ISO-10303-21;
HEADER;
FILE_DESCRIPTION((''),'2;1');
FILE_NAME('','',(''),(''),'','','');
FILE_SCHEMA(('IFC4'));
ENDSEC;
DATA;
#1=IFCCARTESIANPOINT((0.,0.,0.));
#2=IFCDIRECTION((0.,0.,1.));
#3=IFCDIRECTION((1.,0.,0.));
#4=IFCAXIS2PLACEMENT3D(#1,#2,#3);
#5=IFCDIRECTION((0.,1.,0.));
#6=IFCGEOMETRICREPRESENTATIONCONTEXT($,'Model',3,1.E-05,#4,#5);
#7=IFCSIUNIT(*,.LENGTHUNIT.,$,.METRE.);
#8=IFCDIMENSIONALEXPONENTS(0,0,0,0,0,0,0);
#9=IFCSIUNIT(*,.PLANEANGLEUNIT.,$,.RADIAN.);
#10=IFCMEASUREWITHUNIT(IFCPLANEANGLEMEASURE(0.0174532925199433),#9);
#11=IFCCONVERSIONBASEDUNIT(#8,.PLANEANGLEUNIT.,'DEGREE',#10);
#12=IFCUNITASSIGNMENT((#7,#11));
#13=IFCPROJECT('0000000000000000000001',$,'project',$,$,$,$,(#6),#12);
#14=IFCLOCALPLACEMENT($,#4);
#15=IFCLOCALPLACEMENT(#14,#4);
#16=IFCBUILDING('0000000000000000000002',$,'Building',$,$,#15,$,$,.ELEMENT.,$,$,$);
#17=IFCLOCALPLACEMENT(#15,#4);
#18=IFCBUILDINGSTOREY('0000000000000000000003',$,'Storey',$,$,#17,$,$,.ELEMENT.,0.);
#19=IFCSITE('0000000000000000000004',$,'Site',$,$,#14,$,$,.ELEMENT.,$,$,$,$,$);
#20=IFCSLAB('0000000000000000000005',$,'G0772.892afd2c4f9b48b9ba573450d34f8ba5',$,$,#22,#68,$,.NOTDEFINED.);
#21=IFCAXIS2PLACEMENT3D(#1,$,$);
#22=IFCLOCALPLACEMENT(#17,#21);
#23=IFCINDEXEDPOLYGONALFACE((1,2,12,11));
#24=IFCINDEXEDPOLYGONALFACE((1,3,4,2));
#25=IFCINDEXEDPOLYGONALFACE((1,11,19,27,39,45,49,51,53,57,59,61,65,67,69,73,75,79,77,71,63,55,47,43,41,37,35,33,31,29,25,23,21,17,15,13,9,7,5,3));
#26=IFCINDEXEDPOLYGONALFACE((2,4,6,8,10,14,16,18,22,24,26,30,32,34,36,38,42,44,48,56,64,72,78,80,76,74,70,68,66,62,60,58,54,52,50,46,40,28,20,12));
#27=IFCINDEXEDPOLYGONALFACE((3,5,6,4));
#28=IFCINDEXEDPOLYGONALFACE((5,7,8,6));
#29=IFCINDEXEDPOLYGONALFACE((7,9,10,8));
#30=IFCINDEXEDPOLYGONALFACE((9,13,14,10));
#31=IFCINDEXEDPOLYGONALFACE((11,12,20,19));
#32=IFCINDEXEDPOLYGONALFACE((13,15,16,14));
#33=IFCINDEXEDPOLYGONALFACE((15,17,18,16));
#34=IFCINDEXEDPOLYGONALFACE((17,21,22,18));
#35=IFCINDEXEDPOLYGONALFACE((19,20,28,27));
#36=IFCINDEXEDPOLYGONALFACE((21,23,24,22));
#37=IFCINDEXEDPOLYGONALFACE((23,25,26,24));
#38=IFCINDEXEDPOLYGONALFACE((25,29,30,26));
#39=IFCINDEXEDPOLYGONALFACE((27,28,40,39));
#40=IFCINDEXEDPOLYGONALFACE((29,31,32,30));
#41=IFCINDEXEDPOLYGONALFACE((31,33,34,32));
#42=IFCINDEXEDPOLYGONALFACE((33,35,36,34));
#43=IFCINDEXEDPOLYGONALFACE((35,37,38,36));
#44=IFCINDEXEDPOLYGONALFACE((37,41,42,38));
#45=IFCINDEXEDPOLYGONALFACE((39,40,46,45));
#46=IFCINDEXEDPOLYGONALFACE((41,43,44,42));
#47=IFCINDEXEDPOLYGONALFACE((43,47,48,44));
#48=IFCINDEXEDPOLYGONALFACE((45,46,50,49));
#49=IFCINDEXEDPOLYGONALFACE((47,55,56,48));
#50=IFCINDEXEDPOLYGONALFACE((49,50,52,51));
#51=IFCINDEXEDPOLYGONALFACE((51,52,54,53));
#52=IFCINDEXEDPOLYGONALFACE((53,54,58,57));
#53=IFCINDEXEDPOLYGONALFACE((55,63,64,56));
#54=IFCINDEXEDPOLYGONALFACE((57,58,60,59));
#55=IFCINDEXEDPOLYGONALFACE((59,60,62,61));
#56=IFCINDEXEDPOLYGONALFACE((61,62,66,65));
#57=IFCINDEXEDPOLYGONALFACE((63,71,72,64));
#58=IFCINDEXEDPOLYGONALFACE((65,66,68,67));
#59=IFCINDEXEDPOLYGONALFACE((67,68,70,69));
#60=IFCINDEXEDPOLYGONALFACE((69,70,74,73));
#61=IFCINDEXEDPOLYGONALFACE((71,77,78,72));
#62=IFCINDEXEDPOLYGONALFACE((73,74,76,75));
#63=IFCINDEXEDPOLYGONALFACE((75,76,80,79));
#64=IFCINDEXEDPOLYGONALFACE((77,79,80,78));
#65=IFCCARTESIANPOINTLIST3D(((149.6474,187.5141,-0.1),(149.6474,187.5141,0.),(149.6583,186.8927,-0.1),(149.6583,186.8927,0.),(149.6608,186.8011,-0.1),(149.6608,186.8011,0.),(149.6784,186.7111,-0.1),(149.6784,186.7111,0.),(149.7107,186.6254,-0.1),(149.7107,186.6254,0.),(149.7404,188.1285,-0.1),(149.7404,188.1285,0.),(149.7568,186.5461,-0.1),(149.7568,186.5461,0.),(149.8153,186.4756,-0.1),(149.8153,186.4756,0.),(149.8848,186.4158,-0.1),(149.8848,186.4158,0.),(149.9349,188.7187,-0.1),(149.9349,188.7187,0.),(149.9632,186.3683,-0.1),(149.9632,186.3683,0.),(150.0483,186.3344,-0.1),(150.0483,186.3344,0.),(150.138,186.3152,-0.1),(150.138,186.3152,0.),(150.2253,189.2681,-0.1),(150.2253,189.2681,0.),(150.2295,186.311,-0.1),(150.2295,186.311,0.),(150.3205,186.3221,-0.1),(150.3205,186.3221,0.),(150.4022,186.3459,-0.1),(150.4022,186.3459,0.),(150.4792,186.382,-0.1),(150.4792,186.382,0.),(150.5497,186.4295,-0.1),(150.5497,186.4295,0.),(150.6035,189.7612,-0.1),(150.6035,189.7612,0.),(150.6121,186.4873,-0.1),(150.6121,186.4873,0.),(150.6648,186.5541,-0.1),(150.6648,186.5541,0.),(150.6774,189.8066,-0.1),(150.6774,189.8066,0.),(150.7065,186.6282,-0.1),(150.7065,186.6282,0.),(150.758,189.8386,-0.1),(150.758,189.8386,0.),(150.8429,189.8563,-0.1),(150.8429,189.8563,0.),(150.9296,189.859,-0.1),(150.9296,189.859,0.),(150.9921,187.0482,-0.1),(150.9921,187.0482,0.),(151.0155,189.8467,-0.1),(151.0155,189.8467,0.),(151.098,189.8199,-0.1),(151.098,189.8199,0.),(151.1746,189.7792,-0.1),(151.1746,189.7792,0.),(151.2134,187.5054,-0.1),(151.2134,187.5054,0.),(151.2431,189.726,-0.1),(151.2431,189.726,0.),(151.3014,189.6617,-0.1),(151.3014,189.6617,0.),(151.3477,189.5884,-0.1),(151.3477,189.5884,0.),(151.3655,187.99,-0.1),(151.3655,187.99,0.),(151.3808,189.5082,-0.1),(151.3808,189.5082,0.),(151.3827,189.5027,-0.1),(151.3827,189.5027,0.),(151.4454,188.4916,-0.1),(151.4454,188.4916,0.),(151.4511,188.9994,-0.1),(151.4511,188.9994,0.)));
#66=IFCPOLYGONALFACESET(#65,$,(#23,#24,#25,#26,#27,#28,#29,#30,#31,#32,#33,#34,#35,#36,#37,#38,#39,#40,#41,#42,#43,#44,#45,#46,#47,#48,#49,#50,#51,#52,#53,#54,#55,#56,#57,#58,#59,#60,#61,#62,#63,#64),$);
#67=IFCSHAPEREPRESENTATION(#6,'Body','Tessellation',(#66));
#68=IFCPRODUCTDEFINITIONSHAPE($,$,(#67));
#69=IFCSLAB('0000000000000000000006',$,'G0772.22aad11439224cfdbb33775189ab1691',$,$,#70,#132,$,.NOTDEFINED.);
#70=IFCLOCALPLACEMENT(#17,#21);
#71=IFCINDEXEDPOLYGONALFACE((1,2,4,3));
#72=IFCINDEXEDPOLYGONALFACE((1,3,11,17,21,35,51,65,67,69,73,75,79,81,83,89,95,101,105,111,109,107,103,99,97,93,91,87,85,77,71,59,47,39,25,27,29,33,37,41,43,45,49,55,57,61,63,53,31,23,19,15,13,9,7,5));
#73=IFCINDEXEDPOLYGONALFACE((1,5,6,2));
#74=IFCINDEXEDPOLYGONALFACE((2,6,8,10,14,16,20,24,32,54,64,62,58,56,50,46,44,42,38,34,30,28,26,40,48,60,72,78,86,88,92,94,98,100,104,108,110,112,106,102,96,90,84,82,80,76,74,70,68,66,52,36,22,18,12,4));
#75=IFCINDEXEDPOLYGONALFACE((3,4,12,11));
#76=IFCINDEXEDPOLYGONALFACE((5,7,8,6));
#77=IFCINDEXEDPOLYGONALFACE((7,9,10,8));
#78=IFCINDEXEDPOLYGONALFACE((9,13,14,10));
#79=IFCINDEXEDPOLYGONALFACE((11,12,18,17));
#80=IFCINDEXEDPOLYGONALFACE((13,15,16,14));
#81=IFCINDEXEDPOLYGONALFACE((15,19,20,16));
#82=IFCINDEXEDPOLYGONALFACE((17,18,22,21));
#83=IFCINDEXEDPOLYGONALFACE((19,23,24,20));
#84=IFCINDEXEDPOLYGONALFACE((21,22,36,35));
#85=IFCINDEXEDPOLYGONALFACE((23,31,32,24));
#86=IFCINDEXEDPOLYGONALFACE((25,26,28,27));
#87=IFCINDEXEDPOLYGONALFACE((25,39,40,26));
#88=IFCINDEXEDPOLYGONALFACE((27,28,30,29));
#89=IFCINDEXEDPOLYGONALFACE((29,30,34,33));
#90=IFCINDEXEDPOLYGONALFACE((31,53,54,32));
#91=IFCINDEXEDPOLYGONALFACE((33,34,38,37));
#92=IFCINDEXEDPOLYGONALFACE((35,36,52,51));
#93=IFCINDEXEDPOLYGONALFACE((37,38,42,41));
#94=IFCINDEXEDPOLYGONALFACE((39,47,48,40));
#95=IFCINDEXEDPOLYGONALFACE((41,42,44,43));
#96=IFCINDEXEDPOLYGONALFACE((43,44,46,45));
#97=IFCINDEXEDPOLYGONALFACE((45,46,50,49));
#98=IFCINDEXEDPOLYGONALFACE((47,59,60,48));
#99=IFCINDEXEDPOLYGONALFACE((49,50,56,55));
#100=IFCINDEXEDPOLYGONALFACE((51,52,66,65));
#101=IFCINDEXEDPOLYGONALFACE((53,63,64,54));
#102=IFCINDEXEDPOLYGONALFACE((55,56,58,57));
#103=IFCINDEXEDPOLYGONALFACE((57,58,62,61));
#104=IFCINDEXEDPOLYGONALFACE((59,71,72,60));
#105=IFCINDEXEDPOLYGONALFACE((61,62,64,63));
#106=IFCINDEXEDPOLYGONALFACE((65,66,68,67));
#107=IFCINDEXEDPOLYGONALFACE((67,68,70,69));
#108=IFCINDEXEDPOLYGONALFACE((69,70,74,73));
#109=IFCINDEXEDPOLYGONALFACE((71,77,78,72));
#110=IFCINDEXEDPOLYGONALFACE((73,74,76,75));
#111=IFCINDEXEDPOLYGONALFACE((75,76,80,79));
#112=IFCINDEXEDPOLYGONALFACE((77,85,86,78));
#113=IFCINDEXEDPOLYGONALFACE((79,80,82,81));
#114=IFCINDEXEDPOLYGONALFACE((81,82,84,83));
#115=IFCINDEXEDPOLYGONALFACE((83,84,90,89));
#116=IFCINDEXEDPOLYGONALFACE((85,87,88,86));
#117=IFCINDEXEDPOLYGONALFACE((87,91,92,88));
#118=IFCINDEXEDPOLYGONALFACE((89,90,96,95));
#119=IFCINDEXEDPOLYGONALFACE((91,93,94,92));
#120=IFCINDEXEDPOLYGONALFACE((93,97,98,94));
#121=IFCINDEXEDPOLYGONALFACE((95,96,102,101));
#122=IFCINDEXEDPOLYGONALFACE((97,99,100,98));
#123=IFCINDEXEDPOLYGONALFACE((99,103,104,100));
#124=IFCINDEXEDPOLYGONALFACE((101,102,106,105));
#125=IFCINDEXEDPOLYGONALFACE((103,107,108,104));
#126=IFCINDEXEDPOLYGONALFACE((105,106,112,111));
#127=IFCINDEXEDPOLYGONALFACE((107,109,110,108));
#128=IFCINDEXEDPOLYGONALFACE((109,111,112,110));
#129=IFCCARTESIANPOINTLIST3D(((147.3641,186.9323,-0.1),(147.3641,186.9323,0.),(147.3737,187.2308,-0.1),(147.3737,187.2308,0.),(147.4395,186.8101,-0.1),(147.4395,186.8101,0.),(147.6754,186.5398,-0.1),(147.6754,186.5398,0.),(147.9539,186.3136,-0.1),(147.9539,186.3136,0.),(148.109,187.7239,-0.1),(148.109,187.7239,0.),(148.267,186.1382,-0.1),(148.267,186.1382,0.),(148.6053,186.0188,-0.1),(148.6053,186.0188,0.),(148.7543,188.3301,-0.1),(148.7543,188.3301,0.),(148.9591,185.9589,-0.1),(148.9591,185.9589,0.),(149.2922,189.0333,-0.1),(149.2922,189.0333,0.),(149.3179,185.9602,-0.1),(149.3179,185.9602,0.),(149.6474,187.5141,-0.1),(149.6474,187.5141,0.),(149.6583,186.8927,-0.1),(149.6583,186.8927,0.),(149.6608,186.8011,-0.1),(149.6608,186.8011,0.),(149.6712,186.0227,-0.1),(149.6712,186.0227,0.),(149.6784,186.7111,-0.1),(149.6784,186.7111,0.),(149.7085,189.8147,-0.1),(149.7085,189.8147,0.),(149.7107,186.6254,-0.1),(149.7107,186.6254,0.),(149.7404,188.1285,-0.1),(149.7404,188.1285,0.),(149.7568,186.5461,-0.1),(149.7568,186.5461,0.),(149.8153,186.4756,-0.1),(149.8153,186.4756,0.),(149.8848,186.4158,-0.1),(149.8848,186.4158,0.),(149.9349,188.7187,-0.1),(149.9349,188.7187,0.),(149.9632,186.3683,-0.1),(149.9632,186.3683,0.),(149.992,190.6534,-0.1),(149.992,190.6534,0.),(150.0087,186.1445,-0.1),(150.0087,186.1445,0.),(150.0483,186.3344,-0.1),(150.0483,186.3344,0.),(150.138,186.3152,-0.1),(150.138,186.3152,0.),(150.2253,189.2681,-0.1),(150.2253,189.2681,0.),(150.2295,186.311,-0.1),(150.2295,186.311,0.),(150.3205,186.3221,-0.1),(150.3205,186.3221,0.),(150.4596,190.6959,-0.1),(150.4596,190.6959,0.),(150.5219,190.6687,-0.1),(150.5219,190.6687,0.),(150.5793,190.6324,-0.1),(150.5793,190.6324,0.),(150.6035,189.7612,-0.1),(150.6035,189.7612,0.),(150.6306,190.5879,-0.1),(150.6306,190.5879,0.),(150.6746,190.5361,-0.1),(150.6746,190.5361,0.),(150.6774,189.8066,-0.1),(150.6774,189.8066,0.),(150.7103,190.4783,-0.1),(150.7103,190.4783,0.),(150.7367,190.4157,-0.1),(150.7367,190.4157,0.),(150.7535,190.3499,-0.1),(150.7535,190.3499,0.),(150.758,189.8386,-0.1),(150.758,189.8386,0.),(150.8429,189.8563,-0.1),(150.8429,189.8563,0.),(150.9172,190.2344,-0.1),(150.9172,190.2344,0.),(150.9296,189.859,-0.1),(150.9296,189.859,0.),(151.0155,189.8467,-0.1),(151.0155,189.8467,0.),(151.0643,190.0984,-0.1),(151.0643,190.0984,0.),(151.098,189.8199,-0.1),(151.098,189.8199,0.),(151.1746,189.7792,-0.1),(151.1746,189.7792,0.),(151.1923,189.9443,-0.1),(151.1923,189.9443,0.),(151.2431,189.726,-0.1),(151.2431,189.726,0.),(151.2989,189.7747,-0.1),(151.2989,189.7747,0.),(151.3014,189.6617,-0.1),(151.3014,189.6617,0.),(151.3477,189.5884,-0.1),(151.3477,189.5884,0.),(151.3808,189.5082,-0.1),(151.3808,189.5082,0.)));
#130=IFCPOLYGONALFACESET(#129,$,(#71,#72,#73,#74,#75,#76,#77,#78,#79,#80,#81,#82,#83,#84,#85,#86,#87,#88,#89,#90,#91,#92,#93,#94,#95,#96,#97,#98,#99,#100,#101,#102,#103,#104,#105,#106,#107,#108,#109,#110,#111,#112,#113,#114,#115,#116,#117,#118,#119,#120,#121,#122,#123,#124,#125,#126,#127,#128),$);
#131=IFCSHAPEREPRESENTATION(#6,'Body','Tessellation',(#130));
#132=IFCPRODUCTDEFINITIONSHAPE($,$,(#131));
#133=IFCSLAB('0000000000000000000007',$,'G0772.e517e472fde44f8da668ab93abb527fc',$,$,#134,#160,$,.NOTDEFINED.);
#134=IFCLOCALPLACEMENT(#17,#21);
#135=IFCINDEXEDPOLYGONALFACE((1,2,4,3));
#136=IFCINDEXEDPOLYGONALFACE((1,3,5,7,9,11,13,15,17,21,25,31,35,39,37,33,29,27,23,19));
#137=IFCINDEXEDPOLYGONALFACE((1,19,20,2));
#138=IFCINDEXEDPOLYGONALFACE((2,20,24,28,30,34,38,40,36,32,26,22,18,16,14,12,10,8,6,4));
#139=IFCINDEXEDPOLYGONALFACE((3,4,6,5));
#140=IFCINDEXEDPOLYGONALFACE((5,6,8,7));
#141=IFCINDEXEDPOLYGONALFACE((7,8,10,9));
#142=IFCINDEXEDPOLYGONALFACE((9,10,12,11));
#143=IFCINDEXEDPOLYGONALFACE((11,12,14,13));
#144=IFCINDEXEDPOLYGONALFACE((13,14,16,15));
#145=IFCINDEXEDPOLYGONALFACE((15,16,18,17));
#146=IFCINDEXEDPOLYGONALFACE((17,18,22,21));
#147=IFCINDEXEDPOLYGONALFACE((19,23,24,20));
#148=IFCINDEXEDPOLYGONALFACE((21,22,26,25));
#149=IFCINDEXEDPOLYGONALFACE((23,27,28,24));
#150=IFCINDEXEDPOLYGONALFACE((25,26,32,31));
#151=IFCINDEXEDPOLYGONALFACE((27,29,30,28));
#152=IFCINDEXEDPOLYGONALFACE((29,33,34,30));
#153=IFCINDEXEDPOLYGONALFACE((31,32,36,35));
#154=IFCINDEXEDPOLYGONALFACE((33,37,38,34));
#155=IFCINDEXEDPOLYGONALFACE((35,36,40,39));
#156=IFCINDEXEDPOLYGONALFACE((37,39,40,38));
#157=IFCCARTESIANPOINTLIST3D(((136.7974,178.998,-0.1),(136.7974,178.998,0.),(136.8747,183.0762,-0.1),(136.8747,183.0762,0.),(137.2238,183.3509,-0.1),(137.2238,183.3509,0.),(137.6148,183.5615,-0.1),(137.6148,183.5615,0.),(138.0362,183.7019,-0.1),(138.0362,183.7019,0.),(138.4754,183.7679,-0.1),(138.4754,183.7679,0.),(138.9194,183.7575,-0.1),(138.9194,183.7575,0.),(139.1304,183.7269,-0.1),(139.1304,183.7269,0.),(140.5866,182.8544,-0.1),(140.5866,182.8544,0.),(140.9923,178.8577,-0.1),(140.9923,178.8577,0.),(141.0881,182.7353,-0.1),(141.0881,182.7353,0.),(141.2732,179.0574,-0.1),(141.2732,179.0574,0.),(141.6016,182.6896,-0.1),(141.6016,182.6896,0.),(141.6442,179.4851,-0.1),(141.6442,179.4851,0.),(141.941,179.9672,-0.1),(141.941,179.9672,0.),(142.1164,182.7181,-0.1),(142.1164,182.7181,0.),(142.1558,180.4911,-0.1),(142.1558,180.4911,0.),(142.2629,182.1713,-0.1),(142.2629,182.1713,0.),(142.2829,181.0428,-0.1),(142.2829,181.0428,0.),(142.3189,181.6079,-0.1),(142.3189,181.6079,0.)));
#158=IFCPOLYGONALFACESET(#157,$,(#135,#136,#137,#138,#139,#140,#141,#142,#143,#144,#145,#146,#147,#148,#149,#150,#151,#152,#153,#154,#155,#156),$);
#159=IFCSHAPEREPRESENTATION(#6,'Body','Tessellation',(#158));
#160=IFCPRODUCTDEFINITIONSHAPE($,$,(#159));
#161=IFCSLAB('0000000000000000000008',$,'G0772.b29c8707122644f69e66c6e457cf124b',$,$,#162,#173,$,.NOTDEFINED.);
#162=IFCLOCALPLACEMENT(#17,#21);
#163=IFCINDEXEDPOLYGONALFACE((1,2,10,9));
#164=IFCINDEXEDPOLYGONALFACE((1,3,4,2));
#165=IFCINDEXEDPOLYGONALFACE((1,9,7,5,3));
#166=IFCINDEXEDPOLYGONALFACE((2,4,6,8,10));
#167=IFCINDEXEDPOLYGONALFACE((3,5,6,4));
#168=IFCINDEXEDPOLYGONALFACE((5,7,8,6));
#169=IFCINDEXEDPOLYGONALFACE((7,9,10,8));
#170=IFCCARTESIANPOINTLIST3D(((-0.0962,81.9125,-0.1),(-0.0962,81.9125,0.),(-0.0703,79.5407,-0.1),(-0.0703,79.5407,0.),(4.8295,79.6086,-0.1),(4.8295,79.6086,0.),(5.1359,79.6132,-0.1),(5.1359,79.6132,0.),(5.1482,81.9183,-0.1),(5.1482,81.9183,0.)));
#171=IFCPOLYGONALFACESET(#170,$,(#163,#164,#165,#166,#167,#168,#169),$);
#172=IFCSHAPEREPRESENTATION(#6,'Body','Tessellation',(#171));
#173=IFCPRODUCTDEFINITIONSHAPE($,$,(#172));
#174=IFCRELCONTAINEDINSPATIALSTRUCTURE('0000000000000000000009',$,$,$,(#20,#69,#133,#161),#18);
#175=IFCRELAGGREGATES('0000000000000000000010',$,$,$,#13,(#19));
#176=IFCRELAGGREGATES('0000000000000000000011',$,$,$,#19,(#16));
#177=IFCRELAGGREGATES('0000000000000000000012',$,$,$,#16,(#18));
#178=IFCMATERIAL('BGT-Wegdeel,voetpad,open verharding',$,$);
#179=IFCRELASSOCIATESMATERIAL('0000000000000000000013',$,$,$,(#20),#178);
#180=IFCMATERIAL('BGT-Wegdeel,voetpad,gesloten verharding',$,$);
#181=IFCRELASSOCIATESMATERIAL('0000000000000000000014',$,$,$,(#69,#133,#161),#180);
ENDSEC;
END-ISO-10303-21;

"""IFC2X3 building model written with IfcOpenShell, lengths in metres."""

from ifc_helpers import new_model, entity, si_unit, converted_unit, direction, frame, origin_with_axes, place, context, project, spatial, polyline, outline, extrude, material, element, save


model = new_model("IFC2X3")

# Units and contexts
model_context = context("Model", 3, precision=1e-05, world=origin_with_axes(), true_north=direction((0.0, 1.0, 0.0)))
ifc_project = project(units=[si_unit("LENGTHUNIT", "METRE"), converted_unit("PLANEANGLEUNIT", "DEGREE", entity("IfcPlaneAngleMeasure", 0.0174532925199433), si_unit("PLANEANGLEUNIT", "RADIAN"), dimensions=[0, 0, 0, 0, 0, 0, 0])], contexts=[model_context])

# Site, building, storey
site_placement = place(None, origin_with_axes())
site = spatial("IfcSite", under=ifc_project, at=site_placement, Name="Site", CompositionType="ELEMENT")
building_placement = place(site_placement, origin_with_axes())
building = spatial("IfcBuilding", under=site, at=building_placement, Name="Building", CompositionType="ELEMENT")
storey_placement = place(building_placement, origin_with_axes())
storey = spatial("IfcBuildingStorey", under=building, at=storey_placement, Name="Storey", CompositionType="ELEMENT", Elevation=0.0)

# Slabs
ifc_material_1 = material(Name="BGT-Wegdeel,voetpad,open verharding")
ifc_material_2 = material(Name="BGT-Wegdeel,voetpad,gesloten verharding")
slab_1_placement = place(storey_placement, frame((0.0, 0.0, -0.1), z_axis=(0.0, 0.0, 1.0), x_axis=(1.0, 0.0, 0.0)))
element("IfcSlab", 1, at=slab_1_placement, inside=storey, material=ifc_material_1, Name="G0772.892afd2c4f9b48b9ba573450d34f8ba5", PredefinedType="NOTDEFINED", context=model_context, shape_type="SweptSolid", body=[
    extrude(outline(polyline([(151.4511, 188.9994), (151.4454, 188.4916), (151.3655, 187.99), (151.2134, 187.5054), (150.9921, 187.0482), (150.7065, 186.6282), (150.6648, 186.5541), (150.6121, 186.4873), (150.5497, 186.4295), (150.4792, 186.382), (150.4022, 186.3459), (150.3205, 186.3221), (150.2295, 186.311), (150.138, 186.3152), (150.0483, 186.3344), (149.9632, 186.3683), (149.8848, 186.4158), (149.8153, 186.4756), (149.7568, 186.5461), (149.7107, 186.6254), (149.6784, 186.7111), (149.6608, 186.8011), (149.6583, 186.8927), (149.6474, 187.5141), (149.7404, 188.1285), (149.9349, 188.7187), (150.2253, 189.2681), (150.6035, 189.7612), (150.6774, 189.8066), (150.758, 189.8386), (150.8429, 189.8563), (150.9296, 189.859), (151.0155, 189.8467), (151.098, 189.8199), (151.1746, 189.7792), (151.2431, 189.726), (151.3014, 189.6617), (151.3477, 189.5884), (151.3808, 189.5082), (151.3827, 189.5027), (151.4511, 188.9994)])), origin_with_axes(), (0.0, 0.0, 1.0), 0.1),
])
slab_2_placement = place(storey_placement, frame((0.0, 0.0, -0.1), z_axis=(0.0, 0.0, 1.0), x_axis=(1.0, 0.0, 0.0)))
element("IfcSlab", 2, at=slab_2_placement, inside=storey, material=ifc_material_2, Name="G0772.22aad11439224cfdbb33775189ab1691", PredefinedType="NOTDEFINED", context=model_context, shape_type="SweptSolid", body=[
    extrude(outline(polyline([(151.3477, 189.5884), (151.3014, 189.6617), (151.2431, 189.726), (151.1746, 189.7792), (151.098, 189.8199), (151.0155, 189.8467), (150.9296, 189.859), (150.8429, 189.8563), (150.758, 189.8386), (150.6774, 189.8066), (150.6035, 189.7612), (150.2253, 189.2681), (149.9349, 188.7187), (149.7404, 188.1285), (149.6474, 187.5141), (149.6583, 186.8927), (149.6608, 186.8011), (149.6784, 186.7111), (149.7107, 186.6254), (149.7568, 186.5461), (149.8153, 186.4756), (149.8848, 186.4158), (149.9632, 186.3683), (150.0483, 186.3344), (150.138, 186.3152), (150.2295, 186.311), (150.3205, 186.3221), (150.0087, 186.1445), (149.6712, 186.0227), (149.3179, 185.9602), (148.9591, 185.9589), (148.6053, 186.0188), (148.267, 186.1382), (147.9539, 186.3136), (147.6754, 186.5398), (147.4395, 186.8101), (147.3641, 186.9323), (147.3737, 187.2308), (148.109, 187.7239), (148.7543, 188.3301), (149.2922, 189.0333), (149.7085, 189.8147), (149.992, 190.6534), (150.4596, 190.6959), (150.5219, 190.6687), (150.5793, 190.6324), (150.6306, 190.5879), (150.6746, 190.5361), (150.7103, 190.4783), (150.7367, 190.4157), (150.7535, 190.3499), (150.9172, 190.2344), (151.0643, 190.0984), (151.1923, 189.9443), (151.2989, 189.7747), (151.3808, 189.5082), (151.3477, 189.5884)])), origin_with_axes(), (0.0, 0.0, 1.0), 0.1),
])
slab_3_placement = place(storey_placement, frame((0.0, 0.0, -0.1), z_axis=(0.0, 0.0, 1.0), x_axis=(1.0, 0.0, 0.0)))
element("IfcSlab", 3, at=slab_3_placement, inside=storey, material=ifc_material_2, Name="G0772.e517e472fde44f8da668ab93abb527fc", PredefinedType="NOTDEFINED", context=model_context, shape_type="SweptSolid", body=[
    extrude(outline(polyline([(140.5866, 182.8544), (141.0881, 182.7353), (141.6016, 182.6896), (142.1164, 182.7181), (142.2629, 182.1713), (142.3189, 181.6079), (142.2829, 181.0428), (142.1558, 180.4911), (141.941, 179.9672), (141.6442, 179.4851), (141.2732, 179.0574), (140.9923, 178.8577), (136.7974, 178.998), (136.8747, 183.0762), (137.2238, 183.3509), (137.6148, 183.5615), (138.0362, 183.7019), (138.4754, 183.7679), (138.9194, 183.7575), (139.1304, 183.7269), (140.5866, 182.8544)])), origin_with_axes(), (0.0, 0.0, 1.0), 0.1),
])
slab_4_placement = place(storey_placement, frame((0.0, 0.0, -0.1), z_axis=(0.0, 0.0, 1.0), x_axis=(1.0, 0.0, 0.0)))
element("IfcSlab", 4, at=slab_4_placement, inside=storey, material=ifc_material_2, Name="G0772.b29c8707122644f69e66c6e457cf124b", PredefinedType="NOTDEFINED", context=model_context, shape_type="SweptSolid", body=[
    extrude(outline(polyline([(5.1482, 81.9183), (5.1359, 79.6132), (4.8295, 79.6086), (-0.0703, 79.5407), (-0.0962, 81.9125), (5.1482, 81.9183)])), origin_with_axes(), (0.0, 0.0, 1.0), 0.1),
])

save(model, "model.ifc")
